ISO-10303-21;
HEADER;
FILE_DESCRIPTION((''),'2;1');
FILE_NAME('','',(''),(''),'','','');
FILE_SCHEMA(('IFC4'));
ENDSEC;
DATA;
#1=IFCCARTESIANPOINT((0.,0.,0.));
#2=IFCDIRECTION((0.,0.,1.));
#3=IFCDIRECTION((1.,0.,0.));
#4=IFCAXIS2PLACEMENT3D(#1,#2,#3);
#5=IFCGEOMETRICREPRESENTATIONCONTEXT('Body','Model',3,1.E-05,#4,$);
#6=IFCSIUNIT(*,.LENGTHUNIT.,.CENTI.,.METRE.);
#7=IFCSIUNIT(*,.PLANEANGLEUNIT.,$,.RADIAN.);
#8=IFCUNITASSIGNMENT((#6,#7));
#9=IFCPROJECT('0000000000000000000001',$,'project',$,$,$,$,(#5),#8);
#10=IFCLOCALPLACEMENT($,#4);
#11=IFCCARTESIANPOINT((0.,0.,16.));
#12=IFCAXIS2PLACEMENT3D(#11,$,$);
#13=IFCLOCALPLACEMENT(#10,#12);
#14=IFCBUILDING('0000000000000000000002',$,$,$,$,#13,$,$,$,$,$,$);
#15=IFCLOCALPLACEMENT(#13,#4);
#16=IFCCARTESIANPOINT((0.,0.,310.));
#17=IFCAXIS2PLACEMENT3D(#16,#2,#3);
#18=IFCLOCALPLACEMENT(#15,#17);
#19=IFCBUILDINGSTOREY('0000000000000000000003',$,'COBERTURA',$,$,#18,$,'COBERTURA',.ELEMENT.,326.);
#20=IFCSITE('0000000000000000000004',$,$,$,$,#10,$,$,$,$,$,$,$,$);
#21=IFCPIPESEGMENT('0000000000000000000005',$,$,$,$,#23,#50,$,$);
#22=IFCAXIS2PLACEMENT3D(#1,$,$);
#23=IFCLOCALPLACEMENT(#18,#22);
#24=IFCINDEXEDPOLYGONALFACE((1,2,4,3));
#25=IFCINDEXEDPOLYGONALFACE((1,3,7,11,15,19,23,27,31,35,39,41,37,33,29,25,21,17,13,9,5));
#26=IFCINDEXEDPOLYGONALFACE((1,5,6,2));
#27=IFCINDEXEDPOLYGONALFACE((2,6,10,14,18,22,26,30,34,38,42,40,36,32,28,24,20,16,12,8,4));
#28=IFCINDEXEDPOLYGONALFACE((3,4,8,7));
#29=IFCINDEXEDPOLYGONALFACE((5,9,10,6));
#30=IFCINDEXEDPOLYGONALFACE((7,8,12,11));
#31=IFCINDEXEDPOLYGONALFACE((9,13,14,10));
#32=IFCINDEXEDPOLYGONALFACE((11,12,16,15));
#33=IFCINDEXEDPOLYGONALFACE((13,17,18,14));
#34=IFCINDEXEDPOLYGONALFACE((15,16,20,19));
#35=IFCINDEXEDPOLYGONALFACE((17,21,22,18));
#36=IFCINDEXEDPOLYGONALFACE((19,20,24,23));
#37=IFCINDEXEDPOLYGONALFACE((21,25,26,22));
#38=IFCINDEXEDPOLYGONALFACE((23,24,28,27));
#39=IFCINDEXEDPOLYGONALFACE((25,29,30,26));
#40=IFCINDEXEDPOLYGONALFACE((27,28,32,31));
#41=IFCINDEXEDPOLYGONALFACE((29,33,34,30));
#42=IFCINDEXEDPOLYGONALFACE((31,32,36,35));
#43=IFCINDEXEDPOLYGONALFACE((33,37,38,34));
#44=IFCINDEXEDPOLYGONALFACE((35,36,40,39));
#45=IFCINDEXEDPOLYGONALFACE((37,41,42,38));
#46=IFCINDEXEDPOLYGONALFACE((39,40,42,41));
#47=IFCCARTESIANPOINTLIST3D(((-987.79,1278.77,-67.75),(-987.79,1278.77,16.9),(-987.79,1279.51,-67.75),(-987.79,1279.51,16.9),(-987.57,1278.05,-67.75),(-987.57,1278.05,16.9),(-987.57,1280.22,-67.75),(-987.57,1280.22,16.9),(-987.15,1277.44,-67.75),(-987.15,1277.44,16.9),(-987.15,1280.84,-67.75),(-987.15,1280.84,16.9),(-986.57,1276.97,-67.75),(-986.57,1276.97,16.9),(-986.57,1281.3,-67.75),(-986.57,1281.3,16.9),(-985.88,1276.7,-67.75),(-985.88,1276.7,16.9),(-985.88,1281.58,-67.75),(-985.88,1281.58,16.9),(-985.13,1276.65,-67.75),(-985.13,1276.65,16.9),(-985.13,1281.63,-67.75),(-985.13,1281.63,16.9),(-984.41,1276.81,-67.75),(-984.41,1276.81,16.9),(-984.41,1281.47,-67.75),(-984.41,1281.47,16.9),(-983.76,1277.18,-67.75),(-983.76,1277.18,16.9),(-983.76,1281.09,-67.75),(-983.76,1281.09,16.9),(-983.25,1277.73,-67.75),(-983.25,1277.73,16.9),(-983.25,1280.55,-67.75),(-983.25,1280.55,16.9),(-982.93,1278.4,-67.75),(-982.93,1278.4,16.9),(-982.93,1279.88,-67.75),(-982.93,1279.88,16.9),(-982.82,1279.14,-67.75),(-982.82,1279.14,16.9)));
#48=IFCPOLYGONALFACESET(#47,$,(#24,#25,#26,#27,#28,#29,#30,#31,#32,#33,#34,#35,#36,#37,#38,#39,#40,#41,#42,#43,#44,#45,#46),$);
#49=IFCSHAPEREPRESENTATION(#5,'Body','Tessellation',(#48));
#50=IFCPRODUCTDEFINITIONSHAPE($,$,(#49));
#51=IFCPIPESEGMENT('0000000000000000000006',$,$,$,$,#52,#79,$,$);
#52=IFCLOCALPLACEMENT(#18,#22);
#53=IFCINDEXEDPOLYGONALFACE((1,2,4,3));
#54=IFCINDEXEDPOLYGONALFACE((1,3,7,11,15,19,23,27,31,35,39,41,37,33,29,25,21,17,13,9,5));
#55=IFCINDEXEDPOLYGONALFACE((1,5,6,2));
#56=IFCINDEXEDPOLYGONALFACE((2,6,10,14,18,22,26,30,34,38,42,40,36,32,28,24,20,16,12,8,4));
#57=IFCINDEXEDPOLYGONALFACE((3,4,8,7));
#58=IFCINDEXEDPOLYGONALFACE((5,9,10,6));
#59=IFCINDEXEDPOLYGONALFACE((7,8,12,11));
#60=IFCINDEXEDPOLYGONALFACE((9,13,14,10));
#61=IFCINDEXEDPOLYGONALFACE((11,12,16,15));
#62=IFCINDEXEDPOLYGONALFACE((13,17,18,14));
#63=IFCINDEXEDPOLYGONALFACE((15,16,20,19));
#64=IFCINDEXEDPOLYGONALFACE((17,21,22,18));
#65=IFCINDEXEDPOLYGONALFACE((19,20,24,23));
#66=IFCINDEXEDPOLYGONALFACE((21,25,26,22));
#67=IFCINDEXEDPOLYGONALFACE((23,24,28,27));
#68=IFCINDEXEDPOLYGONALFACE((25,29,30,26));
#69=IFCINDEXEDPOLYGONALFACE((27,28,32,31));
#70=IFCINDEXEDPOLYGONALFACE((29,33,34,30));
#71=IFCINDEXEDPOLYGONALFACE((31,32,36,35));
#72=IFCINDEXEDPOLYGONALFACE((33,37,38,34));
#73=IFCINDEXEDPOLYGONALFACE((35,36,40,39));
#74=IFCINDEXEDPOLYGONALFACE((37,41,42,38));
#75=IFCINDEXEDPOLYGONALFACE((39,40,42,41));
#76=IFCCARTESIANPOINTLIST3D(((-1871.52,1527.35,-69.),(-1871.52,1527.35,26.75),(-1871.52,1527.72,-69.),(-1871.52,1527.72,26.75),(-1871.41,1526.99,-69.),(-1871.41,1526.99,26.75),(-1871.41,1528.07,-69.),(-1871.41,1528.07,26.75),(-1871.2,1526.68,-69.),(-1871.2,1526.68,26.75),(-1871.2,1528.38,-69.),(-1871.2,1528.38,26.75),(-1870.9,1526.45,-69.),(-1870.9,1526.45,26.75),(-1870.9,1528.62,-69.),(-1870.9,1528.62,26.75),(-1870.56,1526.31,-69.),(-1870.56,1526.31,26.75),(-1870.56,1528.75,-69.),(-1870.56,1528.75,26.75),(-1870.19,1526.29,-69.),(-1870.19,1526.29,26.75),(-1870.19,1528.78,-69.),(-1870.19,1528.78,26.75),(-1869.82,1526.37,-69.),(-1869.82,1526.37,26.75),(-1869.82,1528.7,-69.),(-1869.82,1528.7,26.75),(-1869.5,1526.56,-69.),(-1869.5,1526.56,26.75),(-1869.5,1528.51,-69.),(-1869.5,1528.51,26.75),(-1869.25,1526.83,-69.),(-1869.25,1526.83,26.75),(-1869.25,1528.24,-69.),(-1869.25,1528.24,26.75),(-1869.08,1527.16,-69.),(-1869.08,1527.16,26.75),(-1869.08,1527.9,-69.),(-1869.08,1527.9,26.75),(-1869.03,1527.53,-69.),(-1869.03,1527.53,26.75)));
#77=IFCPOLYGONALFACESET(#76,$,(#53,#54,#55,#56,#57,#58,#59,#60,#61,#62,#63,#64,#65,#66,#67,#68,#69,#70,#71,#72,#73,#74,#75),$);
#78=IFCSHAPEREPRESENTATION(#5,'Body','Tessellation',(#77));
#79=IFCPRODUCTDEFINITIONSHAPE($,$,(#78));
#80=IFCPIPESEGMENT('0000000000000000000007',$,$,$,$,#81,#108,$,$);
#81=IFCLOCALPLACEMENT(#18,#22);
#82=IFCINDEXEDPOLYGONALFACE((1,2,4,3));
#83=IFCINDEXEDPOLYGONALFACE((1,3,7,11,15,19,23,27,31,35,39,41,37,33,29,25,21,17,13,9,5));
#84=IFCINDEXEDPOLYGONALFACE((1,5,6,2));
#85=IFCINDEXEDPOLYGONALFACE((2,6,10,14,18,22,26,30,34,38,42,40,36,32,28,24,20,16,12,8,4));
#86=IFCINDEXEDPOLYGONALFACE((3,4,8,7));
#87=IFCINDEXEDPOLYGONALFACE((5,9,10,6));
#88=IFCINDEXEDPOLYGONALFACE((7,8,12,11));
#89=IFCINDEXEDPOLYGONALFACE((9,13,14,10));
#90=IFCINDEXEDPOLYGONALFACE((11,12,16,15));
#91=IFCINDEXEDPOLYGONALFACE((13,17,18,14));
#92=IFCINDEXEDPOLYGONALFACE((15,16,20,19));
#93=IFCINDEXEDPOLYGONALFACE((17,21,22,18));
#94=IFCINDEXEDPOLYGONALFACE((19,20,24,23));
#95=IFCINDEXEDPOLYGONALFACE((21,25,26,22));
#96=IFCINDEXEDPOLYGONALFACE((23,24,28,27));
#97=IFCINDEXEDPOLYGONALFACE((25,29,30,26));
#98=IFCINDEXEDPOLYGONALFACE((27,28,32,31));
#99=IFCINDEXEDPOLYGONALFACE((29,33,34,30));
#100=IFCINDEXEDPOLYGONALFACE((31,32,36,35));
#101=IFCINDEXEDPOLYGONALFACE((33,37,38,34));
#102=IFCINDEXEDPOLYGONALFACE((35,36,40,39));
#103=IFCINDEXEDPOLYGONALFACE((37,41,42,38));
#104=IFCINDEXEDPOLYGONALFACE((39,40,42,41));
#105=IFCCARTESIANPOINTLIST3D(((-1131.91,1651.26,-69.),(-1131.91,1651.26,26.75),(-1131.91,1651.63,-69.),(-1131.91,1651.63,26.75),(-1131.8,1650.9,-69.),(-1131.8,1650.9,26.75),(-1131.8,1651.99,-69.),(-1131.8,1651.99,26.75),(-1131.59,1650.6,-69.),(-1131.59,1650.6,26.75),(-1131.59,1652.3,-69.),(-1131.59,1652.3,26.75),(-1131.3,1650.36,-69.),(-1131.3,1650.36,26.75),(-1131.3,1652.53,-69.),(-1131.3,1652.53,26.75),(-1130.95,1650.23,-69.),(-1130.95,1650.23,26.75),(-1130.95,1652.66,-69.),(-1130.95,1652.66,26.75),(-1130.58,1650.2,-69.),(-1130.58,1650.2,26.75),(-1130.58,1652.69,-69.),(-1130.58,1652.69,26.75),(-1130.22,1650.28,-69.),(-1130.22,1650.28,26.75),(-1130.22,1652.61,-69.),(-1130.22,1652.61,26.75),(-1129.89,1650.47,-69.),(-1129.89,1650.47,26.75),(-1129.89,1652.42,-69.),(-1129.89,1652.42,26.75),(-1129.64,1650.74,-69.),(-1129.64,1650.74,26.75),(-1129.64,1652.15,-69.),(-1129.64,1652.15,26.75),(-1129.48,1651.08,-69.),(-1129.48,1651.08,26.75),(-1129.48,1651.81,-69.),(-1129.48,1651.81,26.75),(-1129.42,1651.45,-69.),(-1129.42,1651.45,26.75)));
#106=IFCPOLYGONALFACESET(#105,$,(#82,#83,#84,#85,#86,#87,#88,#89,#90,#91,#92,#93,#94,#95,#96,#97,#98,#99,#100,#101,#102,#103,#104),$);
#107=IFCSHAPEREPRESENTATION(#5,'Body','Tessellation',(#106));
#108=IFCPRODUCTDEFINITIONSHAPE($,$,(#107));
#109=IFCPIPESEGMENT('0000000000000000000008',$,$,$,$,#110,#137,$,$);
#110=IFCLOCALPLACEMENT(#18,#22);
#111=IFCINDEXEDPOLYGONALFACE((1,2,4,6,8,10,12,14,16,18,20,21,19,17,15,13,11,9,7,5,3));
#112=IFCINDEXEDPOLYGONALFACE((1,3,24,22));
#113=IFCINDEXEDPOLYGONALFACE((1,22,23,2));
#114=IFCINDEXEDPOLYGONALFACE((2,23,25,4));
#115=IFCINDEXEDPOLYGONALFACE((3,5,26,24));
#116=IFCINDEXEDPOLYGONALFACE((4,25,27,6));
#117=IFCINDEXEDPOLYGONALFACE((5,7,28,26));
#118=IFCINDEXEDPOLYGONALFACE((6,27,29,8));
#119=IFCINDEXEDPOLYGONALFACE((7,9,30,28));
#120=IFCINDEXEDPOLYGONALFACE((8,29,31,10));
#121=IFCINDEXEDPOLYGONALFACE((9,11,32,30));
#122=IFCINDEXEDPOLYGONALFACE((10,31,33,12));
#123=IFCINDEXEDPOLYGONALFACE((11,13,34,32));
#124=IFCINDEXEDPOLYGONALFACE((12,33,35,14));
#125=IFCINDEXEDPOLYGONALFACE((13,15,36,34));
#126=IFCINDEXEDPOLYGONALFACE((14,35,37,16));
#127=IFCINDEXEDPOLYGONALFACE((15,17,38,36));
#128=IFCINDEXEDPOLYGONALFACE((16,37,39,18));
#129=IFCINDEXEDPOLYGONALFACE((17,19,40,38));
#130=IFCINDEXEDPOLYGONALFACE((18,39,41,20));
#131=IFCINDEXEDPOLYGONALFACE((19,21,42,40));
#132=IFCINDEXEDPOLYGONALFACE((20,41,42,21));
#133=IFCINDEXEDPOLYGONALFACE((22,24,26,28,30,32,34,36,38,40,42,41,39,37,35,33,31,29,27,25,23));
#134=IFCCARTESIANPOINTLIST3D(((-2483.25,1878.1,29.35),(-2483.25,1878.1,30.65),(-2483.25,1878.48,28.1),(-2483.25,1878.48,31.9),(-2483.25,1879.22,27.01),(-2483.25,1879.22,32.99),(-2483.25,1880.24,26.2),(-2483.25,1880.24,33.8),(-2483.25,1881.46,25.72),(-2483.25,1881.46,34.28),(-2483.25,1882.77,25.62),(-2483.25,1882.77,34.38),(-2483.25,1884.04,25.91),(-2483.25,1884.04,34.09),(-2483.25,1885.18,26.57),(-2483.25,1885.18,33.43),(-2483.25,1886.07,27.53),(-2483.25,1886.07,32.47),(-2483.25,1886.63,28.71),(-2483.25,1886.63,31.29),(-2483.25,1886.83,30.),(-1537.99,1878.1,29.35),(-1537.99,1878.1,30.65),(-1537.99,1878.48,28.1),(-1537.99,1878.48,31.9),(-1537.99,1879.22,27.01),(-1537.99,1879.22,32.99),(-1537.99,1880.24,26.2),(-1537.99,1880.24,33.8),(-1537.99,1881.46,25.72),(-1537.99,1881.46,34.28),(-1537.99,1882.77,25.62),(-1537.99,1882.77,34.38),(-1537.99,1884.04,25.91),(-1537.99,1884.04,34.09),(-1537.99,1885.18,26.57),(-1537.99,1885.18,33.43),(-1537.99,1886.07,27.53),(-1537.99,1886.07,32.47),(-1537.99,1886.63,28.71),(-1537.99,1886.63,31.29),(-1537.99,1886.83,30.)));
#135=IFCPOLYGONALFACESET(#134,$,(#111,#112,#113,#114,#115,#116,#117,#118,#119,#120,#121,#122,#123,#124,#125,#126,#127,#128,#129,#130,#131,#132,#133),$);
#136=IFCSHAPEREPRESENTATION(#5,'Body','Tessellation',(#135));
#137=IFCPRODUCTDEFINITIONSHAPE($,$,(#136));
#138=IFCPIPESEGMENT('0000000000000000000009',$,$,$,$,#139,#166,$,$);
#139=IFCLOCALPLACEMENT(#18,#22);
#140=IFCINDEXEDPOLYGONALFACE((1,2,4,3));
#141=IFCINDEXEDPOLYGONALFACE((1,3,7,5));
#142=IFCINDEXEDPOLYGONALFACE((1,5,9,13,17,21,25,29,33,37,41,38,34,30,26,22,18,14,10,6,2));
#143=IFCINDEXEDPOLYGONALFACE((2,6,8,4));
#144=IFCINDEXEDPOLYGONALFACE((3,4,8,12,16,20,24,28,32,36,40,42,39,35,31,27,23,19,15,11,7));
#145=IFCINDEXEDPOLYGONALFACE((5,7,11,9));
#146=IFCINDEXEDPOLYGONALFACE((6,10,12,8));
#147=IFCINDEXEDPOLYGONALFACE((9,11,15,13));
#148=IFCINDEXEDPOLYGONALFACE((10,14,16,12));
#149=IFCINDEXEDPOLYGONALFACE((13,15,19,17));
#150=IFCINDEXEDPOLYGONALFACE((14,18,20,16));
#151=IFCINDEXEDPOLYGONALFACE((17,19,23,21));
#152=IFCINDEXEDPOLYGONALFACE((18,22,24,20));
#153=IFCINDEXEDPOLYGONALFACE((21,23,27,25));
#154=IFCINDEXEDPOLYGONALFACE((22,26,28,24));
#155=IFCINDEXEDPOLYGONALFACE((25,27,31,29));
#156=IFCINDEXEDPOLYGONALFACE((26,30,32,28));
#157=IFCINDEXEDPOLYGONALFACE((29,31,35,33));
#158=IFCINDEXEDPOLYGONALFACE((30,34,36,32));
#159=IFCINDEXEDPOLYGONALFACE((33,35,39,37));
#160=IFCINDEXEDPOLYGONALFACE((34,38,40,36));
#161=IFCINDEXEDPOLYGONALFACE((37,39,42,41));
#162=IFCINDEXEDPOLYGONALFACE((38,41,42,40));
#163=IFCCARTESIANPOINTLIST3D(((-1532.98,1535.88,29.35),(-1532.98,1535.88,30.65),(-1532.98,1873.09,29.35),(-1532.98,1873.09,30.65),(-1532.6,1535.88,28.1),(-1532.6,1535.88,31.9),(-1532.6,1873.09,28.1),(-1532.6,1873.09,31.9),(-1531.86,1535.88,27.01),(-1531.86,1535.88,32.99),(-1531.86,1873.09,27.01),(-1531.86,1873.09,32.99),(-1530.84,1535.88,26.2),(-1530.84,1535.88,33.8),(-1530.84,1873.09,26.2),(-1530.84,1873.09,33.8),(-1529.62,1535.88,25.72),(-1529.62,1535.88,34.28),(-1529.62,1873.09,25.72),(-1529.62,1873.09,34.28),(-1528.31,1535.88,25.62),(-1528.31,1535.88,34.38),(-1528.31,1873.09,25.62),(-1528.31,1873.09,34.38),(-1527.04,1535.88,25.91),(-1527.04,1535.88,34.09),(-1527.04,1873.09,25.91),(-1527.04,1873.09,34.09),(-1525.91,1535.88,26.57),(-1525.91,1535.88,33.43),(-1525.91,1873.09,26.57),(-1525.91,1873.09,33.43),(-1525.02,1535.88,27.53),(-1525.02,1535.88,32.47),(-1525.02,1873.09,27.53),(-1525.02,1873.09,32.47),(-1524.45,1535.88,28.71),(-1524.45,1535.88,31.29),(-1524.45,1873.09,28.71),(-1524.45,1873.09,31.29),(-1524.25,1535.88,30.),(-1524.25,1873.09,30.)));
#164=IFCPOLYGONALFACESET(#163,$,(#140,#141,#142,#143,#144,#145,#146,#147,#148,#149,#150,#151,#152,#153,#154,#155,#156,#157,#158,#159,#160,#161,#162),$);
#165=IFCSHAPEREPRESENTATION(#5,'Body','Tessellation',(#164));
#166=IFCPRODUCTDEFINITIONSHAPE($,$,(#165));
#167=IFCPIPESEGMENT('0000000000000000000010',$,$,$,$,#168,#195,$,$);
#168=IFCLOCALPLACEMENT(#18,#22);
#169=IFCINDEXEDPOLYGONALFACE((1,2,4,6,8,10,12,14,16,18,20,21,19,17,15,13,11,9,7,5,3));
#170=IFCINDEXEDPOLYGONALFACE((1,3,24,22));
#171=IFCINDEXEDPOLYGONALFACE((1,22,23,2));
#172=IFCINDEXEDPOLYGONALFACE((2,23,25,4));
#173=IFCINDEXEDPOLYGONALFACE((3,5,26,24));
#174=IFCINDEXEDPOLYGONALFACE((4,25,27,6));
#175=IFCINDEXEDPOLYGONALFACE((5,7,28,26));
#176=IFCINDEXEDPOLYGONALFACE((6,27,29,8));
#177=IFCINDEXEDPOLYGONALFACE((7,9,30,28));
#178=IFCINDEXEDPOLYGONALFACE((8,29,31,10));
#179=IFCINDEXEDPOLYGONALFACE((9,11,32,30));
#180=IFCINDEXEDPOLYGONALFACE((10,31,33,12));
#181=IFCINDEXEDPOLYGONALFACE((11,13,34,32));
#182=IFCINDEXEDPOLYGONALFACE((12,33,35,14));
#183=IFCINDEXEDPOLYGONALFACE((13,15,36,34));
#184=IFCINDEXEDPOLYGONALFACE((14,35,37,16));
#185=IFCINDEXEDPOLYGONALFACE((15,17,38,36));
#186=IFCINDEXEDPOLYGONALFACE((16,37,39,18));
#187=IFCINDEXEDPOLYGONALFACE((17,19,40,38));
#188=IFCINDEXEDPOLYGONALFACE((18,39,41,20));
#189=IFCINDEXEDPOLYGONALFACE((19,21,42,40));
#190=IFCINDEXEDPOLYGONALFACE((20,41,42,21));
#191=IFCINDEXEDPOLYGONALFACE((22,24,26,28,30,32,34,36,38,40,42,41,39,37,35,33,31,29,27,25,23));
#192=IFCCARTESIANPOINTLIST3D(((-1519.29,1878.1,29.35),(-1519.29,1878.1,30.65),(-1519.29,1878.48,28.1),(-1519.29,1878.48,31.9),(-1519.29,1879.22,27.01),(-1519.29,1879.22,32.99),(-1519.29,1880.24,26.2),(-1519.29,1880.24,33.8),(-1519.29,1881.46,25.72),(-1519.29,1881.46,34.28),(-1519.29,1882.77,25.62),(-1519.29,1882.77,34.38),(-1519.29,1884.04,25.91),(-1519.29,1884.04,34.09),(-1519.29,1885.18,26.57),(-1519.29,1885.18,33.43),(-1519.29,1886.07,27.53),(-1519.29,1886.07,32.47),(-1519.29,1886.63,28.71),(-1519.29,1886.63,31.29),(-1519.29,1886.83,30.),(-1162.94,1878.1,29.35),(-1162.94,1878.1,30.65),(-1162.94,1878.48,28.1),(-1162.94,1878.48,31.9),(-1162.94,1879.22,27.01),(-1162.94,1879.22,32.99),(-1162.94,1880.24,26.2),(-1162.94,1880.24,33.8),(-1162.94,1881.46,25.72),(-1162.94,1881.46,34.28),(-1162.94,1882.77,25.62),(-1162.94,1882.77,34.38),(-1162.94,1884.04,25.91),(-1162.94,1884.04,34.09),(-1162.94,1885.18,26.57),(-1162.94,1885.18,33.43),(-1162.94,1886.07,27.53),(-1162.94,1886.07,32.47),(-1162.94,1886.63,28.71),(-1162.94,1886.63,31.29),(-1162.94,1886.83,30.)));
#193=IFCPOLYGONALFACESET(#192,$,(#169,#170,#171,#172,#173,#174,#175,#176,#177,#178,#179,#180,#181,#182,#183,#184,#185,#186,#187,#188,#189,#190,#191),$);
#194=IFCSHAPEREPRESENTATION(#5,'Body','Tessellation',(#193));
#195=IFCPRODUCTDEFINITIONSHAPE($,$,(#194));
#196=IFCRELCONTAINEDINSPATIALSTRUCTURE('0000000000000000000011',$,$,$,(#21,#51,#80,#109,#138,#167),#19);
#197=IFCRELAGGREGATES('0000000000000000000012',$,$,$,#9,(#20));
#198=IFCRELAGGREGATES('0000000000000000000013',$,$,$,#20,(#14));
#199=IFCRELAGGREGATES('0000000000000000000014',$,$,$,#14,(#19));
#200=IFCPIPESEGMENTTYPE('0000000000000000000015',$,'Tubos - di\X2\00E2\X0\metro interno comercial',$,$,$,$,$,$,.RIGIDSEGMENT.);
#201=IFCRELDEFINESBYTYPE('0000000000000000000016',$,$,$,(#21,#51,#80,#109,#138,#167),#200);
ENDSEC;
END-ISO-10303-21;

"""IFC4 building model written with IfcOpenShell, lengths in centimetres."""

from ifc_helpers import new_model, si_unit, frame, origin_with_axes, origin_2d_with_axis, place, context, project, spatial, circle, extrude, type_object, element, save


model = new_model("IFC4")

# Units and contexts
model_context = context("Model", 3, precision=1e-05, world=origin_with_axes(), identifier="Body")
ifc_project = project(units=[si_unit("LENGTHUNIT", "METRE", prefix="CENTI"), si_unit("PLANEANGLEUNIT", "RADIAN")], contexts=[model_context])

# Site, building, storey
site_placement = place(None, origin_with_axes())
site = spatial("IfcSite", under=ifc_project, at=site_placement)
building_placement = place(site_placement, frame((0.0, 0.0, 16.0)))
building = spatial("IfcBuilding", under=site, at=building_placement)
placement = place(building_placement, origin_with_axes())
storey_placement = place(placement, frame((0.0, 0.0, 310.0), z_axis=(0.0, 0.0, 1.0), x_axis=(1.0, 0.0, 0.0)))
storey = spatial("IfcBuildingStorey", under=building, at=storey_placement, Name="COBERTURA", LongName="COBERTURA", CompositionType="ELEMENT", Elevation=326.0)

# Pipe segments
pipe_segment_type = type_object("IfcPipeSegmentType", Name="Tubos - diâmetro interno comercial", PredefinedType="RIGIDSEGMENT")
pipe_segment_1_placement = place(storey_placement, frame((-985.32, 1279.14, 16.9), z_axis=(0.0, 0.0, 1.0), x_axis=(1.0, 0.0, 0.0)))
element("IfcPipeSegment", 1, at=pipe_segment_1_placement, inside=storey, type_object=pipe_segment_type, context=model_context, shape_type="SolidModel", body=[
    extrude(circle(Radius=2.5, at=origin_2d_with_axis()), frame((0.0, 0.0, 0.0), z_axis=(0.0, 0.0, -1.0), x_axis=(1.0, 0.0, 0.0)), (0.0, 0.0, 1.0), 84.65),
])
for number, where, z_axis, x_axis in (
    (2, (-1870.28, 1527.53, 26.75), (0.0, 0.0, 1.0), (1.0, 0.0, 0.0)),
    (3, (-1130.67, 1651.45, 26.75), (0.0, 0.0, 1.0), (1.0, 0.0, 0.0)),
):
    element("IfcPipeSegment", number, at=place(storey_placement, frame(where, z_axis=z_axis, x_axis=x_axis)), inside=storey, type_object=pipe_segment_type, context=model_context, shape_type="SolidModel", body=[
        extrude(circle(Radius=1.25, at=origin_2d_with_axis()), frame((0.0, 0.0, 0.0), z_axis=(0.0, 0.0, -1.0), x_axis=(1.0, 0.0, 0.0)), (0.0, 0.0, 1.0), 95.75),
    ])
pipe_segment_2_placement = place(storey_placement, frame((-2010.62, 1882.44, 34.39), z_axis=(0.0, 0.0, 1.0), x_axis=(1.0, 0.0, 0.0)))
element("IfcPipeSegment", 4, at=pipe_segment_2_placement, inside=storey, type_object=pipe_segment_type, context=model_context, shape_type="SolidModel", body=[
    extrude(circle(Radius=4.39, at=origin_2d_with_axis()), frame((-472.63, 0.0, -4.39), z_axis=(1.0, 0.0, 0.0), x_axis=(0.0, 1.0, 0.0)), (0.0, 0.0, 1.0), 945.26),
])
pipe_segment_3_placement = place(storey_placement, frame((-1528.64, 1704.49, 34.39), z_axis=(0.0, 0.0, 1.0), x_axis=(1.0, 0.0, 0.0)))
element("IfcPipeSegment", 5, at=pipe_segment_3_placement, inside=storey, type_object=pipe_segment_type, context=model_context, shape_type="SolidModel", body=[
    extrude(circle(Radius=4.39, at=origin_2d_with_axis()), frame((0.0, 168.6, -4.39), z_axis=(0.0, -1.0, 0.0), x_axis=(1.0, 0.0, 0.0)), (0.0, 0.0, 1.0), 337.21),
])
pipe_segment_4_placement = place(storey_placement, frame((-1341.11, 1882.44, 34.39), z_axis=(0.0, 0.0, 1.0), x_axis=(1.0, 0.0, 0.0)))
element("IfcPipeSegment", 6, at=pipe_segment_4_placement, inside=storey, type_object=pipe_segment_type, context=model_context, shape_type="SolidModel", body=[
    extrude(circle(Radius=4.39, at=origin_2d_with_axis()), frame((-178.18, 0.0, -4.39), z_axis=(1.0, 0.0, 0.0), x_axis=(0.0, 1.0, 0.0)), (0.0, 0.0, 1.0), 356.36),
])

save(model, "model.ifc")
